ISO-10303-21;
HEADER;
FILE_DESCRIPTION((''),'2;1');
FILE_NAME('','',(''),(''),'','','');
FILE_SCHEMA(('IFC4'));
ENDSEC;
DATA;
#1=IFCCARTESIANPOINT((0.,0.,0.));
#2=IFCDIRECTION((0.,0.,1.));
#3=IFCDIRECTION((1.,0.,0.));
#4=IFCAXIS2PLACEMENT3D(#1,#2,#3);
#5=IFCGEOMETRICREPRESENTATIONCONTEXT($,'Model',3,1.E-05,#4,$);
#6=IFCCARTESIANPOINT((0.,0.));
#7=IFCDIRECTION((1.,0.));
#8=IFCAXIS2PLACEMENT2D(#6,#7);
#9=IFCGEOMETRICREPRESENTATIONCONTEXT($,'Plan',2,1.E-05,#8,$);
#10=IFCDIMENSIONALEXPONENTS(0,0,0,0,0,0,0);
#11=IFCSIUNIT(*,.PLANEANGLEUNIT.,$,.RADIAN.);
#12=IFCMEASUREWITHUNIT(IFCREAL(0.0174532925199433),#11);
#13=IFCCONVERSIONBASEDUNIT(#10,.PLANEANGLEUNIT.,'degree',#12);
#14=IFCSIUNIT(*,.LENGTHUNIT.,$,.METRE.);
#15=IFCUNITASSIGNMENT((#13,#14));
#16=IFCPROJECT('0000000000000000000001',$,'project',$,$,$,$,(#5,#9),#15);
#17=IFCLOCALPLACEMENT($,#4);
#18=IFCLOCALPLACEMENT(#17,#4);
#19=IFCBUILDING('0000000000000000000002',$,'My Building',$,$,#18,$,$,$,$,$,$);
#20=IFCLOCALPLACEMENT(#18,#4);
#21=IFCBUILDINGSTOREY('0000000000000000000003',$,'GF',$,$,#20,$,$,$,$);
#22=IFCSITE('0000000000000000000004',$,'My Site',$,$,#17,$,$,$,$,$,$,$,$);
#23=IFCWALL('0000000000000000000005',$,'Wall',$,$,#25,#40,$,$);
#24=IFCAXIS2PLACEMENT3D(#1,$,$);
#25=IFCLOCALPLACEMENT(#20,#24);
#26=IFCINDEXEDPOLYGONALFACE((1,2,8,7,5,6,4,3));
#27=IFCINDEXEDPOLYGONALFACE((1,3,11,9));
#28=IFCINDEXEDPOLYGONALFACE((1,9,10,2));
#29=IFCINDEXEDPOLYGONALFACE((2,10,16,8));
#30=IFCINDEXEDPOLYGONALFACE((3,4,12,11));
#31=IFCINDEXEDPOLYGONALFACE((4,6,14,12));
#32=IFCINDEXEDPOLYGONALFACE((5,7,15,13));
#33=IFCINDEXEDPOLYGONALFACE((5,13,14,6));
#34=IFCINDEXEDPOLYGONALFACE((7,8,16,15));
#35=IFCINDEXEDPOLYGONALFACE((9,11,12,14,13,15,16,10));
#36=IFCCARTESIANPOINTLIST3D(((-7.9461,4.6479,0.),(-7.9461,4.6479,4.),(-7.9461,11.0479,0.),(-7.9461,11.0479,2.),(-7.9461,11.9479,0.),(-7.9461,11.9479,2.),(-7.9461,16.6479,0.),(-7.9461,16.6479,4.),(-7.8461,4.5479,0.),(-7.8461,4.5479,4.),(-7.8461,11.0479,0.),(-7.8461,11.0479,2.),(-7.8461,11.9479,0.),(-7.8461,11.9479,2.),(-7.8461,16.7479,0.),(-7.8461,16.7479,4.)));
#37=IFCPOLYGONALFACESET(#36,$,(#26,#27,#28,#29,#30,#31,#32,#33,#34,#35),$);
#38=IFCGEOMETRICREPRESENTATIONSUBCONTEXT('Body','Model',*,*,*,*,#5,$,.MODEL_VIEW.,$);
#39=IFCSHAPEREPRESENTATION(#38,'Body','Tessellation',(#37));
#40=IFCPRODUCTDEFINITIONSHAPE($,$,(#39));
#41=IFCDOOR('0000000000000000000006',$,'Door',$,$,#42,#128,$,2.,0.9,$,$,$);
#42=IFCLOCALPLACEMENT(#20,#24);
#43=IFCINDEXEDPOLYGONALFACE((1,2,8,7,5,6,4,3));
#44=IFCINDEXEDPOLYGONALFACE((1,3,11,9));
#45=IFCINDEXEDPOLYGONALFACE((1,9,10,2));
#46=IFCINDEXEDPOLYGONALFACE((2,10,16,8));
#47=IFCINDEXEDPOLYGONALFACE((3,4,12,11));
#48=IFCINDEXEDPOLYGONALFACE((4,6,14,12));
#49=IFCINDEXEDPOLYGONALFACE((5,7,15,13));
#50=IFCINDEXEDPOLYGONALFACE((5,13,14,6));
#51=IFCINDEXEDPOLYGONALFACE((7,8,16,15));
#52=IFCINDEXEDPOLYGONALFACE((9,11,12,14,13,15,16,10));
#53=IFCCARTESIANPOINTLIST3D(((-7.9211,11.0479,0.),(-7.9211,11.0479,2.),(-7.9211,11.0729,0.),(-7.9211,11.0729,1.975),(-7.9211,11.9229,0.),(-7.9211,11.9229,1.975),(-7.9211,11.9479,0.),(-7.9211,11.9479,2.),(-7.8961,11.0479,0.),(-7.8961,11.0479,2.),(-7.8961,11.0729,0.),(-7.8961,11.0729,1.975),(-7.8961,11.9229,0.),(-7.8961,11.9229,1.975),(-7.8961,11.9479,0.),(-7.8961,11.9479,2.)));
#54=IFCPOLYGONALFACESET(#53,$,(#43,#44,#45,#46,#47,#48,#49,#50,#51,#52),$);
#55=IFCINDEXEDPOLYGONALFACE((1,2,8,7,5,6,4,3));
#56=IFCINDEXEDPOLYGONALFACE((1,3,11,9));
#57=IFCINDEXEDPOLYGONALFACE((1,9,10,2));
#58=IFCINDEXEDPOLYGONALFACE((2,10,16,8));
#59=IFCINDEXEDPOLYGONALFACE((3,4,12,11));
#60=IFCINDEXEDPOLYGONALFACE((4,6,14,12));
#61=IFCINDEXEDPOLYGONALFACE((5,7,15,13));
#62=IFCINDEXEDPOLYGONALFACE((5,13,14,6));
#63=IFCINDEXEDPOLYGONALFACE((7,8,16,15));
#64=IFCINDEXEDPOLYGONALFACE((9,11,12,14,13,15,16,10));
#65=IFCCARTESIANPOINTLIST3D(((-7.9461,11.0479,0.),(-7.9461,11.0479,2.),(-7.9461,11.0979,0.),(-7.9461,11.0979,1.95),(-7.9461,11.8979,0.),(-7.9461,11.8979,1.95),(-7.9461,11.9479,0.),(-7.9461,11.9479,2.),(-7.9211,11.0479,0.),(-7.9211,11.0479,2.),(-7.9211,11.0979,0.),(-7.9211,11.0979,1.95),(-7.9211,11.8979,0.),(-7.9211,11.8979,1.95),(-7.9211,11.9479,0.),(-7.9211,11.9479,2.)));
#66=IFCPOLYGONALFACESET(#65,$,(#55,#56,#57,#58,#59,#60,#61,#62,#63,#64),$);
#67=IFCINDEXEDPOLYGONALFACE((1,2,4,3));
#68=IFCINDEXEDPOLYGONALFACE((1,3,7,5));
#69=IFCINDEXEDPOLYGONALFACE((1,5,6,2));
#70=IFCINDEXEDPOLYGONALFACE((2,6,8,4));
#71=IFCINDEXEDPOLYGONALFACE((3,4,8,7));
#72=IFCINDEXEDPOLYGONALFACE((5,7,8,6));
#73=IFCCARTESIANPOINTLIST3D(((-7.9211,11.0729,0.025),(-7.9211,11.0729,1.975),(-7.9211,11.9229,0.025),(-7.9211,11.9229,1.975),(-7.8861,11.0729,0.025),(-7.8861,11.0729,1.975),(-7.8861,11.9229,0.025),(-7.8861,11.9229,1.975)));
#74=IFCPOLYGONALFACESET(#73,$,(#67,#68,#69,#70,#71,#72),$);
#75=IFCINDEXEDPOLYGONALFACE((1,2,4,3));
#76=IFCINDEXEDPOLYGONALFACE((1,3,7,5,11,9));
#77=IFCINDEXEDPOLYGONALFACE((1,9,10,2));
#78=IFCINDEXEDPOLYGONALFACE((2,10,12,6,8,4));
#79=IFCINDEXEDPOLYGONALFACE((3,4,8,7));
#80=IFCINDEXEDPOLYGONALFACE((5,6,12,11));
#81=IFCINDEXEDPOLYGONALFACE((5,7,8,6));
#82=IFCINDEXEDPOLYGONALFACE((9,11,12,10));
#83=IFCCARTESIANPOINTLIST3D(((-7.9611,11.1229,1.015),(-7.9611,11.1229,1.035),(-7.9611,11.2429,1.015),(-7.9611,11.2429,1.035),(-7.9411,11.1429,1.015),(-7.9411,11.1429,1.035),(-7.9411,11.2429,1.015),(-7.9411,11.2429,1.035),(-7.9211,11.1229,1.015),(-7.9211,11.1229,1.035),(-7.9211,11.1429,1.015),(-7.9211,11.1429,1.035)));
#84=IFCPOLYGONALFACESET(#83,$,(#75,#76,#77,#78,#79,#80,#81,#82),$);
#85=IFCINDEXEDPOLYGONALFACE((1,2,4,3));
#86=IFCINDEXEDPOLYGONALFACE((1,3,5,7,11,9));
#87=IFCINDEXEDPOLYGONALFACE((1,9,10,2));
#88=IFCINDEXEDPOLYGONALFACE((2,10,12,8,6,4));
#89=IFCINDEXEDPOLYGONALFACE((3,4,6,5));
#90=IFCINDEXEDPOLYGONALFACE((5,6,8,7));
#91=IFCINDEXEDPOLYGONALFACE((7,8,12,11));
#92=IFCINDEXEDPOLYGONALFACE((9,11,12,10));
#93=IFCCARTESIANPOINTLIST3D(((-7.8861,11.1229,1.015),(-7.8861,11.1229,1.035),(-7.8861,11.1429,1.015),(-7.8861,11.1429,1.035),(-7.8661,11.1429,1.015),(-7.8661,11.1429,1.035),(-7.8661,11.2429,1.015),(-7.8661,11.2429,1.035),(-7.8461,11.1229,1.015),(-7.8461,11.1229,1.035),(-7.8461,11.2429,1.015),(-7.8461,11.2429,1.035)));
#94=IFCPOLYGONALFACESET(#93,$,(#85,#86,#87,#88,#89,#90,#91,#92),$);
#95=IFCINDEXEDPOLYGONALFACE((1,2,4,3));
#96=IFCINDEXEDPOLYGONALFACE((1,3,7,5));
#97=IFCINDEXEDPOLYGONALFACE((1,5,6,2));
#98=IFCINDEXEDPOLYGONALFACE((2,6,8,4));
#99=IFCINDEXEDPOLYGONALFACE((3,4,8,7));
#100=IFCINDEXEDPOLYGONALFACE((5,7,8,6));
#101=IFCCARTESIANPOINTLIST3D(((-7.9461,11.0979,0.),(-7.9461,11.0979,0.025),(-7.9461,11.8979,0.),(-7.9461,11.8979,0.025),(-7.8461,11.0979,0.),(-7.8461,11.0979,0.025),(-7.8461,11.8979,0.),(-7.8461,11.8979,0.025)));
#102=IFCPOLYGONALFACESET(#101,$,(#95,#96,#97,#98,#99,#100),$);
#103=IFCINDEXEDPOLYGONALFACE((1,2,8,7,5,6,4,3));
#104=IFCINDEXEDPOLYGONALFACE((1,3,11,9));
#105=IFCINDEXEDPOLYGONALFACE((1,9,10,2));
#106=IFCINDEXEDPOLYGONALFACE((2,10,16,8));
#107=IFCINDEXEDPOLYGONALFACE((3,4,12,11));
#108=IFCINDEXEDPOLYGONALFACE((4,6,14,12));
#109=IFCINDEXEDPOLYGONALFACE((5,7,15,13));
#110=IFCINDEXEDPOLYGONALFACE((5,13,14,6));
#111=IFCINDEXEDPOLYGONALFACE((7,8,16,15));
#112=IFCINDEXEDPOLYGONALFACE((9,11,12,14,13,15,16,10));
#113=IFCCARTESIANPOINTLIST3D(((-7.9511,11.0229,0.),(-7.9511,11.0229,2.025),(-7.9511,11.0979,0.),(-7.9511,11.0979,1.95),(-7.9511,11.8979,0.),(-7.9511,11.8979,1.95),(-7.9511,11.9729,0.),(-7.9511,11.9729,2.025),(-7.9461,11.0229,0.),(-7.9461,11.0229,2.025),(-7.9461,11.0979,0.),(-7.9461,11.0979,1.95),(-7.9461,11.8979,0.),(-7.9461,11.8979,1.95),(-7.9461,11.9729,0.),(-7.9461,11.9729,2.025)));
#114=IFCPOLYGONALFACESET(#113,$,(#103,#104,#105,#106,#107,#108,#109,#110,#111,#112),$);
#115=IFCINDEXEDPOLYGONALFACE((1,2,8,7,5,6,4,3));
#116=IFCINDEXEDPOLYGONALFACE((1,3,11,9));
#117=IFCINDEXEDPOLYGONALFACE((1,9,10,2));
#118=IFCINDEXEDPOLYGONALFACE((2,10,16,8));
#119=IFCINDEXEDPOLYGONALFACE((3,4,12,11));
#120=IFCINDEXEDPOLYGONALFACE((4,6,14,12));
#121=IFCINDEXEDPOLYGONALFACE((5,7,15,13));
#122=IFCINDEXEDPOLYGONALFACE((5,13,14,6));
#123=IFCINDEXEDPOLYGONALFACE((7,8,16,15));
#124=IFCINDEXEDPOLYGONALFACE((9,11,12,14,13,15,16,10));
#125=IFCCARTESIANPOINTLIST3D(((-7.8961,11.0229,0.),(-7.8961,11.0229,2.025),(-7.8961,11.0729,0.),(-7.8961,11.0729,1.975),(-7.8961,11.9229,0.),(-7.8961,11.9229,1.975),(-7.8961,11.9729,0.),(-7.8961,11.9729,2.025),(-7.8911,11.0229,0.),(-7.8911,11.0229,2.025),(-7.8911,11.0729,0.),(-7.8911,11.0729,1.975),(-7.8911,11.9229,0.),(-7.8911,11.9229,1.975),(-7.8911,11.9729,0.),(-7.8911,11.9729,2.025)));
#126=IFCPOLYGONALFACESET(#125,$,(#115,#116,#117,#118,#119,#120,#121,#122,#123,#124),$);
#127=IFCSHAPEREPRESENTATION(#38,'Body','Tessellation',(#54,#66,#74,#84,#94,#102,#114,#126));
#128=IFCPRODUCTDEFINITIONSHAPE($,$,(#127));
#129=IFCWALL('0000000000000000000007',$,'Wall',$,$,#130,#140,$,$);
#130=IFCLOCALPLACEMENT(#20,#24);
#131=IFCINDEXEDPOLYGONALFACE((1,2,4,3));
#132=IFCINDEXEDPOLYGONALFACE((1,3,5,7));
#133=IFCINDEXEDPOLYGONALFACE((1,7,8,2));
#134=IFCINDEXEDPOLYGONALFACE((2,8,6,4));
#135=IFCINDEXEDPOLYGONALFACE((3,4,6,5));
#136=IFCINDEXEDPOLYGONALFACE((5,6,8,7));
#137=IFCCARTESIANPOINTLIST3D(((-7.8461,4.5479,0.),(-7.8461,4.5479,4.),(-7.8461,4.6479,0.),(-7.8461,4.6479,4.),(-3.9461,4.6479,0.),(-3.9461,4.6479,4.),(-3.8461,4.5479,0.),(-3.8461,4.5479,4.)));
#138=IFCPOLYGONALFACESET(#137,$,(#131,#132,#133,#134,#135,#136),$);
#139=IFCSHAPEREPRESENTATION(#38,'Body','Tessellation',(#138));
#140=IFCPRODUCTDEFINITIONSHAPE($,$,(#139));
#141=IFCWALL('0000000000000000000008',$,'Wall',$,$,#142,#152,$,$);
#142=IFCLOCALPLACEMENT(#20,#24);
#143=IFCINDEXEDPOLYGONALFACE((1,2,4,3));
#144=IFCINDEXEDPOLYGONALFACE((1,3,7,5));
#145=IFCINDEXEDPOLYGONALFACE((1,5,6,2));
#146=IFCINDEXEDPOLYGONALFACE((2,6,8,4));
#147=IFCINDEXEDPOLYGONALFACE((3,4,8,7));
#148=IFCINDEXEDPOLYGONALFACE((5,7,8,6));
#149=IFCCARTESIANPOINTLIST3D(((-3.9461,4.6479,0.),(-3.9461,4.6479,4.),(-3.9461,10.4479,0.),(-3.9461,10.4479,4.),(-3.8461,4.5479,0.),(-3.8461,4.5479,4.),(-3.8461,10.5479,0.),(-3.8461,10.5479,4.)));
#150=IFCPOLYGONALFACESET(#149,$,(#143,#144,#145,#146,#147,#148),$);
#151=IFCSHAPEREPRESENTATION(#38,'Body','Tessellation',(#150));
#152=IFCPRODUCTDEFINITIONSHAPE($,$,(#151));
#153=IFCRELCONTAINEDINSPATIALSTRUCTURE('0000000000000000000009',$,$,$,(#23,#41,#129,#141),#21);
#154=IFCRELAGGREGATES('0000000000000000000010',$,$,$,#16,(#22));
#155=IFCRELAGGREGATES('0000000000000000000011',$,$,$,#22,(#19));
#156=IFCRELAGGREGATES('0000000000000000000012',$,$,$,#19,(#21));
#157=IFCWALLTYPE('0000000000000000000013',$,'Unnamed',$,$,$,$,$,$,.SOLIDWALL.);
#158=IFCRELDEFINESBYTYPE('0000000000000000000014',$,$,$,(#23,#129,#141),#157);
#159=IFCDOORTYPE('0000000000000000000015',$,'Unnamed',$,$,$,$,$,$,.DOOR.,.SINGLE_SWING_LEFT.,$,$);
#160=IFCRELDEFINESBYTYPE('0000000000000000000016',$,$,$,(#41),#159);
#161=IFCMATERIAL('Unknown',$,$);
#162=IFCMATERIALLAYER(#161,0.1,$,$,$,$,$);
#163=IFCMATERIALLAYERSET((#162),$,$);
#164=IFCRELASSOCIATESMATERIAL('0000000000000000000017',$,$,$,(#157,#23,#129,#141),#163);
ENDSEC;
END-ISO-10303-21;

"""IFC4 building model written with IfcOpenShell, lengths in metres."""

from ifc_helpers import new_model, entity, si_unit, converted_unit, frame, origin_with_axes, origin_2d_with_axis, place, context, subcontext, project, spatial, line, indexed_curve, outline, extrude, shape, source, transform, mapped, material, layer, layer_set, layer_usage, type_object, type_shapes, element, fill, save


model = new_model("IFC4")

# Units and contexts
model_context = context("Model", 3, precision=1e-05, world=origin_with_axes())
plan_context = context("Plan", 2, precision=1e-05, world=origin_2d_with_axis())
body_context_1 = subcontext(model_context, "Body", "Model", "MODEL_VIEW")
body_context_2 = subcontext(plan_context, "Body", "Plan", "PLAN_VIEW")
ifc_project = project(units=[converted_unit("PLANEANGLEUNIT", "degree", entity("IfcReal", 0.0174532925199433), si_unit("PLANEANGLEUNIT", "RADIAN"), dimensions=[0, 0, 0, 0, 0, 0, 0]), si_unit("LENGTHUNIT", "METRE")], contexts=[model_context, plan_context])

# Site, building, storey
site_placement = place(None, origin_with_axes())
site = spatial("IfcSite", under=ifc_project, at=site_placement, Name="My Site")
building_placement = place(site_placement, origin_with_axes())
building = spatial("IfcBuilding", under=site, at=building_placement, Name="My Building")
storey_placement = place(building_placement, origin_with_axes())
storey = spatial("IfcBuildingStorey", under=building, at=storey_placement, Name="GF")

# Shared definitions
ifc_material = material(Name="Unknown")

# Wall, opening, door
ifc_layer_1 = layer(ifc_material, 0.1)
ifc_layer_set_1 = layer_set([ifc_layer_1])
ifc_layer_usage_1 = layer_usage(ifc_layer_set_1, "AXIS2", "POSITIVE", 0.0)
wall_type = type_object("IfcWallType", Name="Unnamed", PredefinedType="SOLIDWALL", material=ifc_layer_set_1)
wall_1_placement = place(storey_placement, frame((-7.9461, 16.6479, 0.0), z_axis=(0.0, 0.0, 1.0), x_axis=(0.0, -1.0, 0.0)))
wall_1 = element("IfcWall", 1, at=wall_1_placement, inside=storey, type_object=wall_type, material=ifc_layer_usage_1, Name="Wall", context=body_context_1, shape_type="SweptSolid", body=[
    extrude(outline(indexed_curve([(0.0, 0.0), (-0.1, 0.1), (12.1, 0.1), (12.0, 0.0)], segments=[line(1, 2, 3, 4, 1)])), origin_with_axes(), (0.0, 0.0, 1.0), 4.0),
])
shared_shape_1 = source(origin_with_axes(), body_context_1, "Body", "SweptSolid", [
    extrude(outline(indexed_curve([(0.0, 0.0), (0.9, 0.0), (0.9, 2.0), (0.0, 2.0)], segments=[line(1, 2, 3, 4, 1)])), frame((0.0, -0.6, 0.0), z_axis=(0.0, -1.0, 0.0), x_axis=(1.0, 0.0, 0.0)), (0.0, 0.0, -1.0), 1.2),
])
opening_1_placement = place(wall_1_placement, frame((4.7001, 0.0, 0.0), z_axis=(0.0, 0.0, 1.0), x_axis=(1.0, 0.0, 0.0)))
opening_1 = element("IfcOpeningElement", 2, at=opening_1_placement, cuts=wall_1, PredefinedType="OPENING", context=body_context_1, shape_type="MappedRepresentation", body=[
    mapped(shared_shape_1, transform((0.0, 0.0, 0.0), x_axis=(1.0, 0.0, 0.0), y_axis=(0.0, 1.0, 0.0), z_axis=(0.0, 0.0, 1.0), scale=1.0)),
])
door_type = type_object("IfcDoorType", Name="Unnamed", OperationType="SINGLE_SWING_LEFT", PredefinedType="DOOR")
shared_shape_2 = source(origin_with_axes(), body_context_1, "Body", "SweptSolid", [
    extrude(outline(indexed_curve([(0.0, 0.0), (0.0, 2.0), (0.9, 2.0), (0.9, 0.0), (0.875, 0.0), (0.875, 1.975), (0.025, 1.975), (0.025, 0.0)], segments=[line(1, 2, 3, 4, 5, 6, 7, 8, 1)])), frame((0.0, 0.025, 0.0), z_axis=(0.0, -1.0, 0.0), x_axis=(1.0, 0.0, 0.0)), (0.0, 0.0, -1.0), 0.025),
    extrude(outline(indexed_curve([(0.0, 0.0), (0.0, 2.0), (0.9, 2.0), (0.9, 0.0), (0.85, 0.0), (0.85, 1.95), (0.05, 1.95), (0.05, 0.0)], segments=[line(1, 2, 3, 4, 5, 6, 7, 8, 1)])), frame((0.0, 0.0, 0.0), z_axis=(0.0, -1.0, 0.0), x_axis=(1.0, 0.0, 0.0)), (0.0, 0.0, -1.0), 0.025),
    extrude(outline(indexed_curve([(0.0, 0.0), (0.85, 0.0), (0.85, 0.035), (0.0, 0.035)], segments=[line(1, 2, 3, 4, 1)])), frame((0.025, 0.025, 0.025), z_axis=(0.0, 0.0, 1.0), x_axis=(1.0, 0.0, 0.0)), (0.0, 0.0, 1.0), 1.95),
    extrude(outline(indexed_curve([(0.0, 0.0), (0.0, -0.04), (-0.12, -0.04), (-0.12, -0.02), (-0.02, -0.02), (-0.02, 0.0)], segments=[line(1, 2, 3, 4, 5, 6, 1)])), frame((0.825, 0.025, 1.015), z_axis=(0.0, 0.0, 1.0), x_axis=(1.0, 0.0, 0.0)), (0.0, 0.0, 1.0), 0.02),
    extrude(outline(indexed_curve([(0.0, 0.0), (0.0, 0.04), (-0.12, 0.04), (-0.12, 0.02), (-0.02, 0.02), (-0.02, 0.0)], segments=[line(1, 2, 3, 4, 5, 6, 1)])), frame((0.825, 0.06, 1.015), z_axis=(0.0, 0.0, 1.0), x_axis=(1.0, 0.0, 0.0)), (0.0, 0.0, 1.0), 0.02),
    extrude(outline(indexed_curve([(0.0, 0.0), (0.8, 0.0), (0.8, 0.1), (0.0, 0.1)], segments=[line(1, 2, 3, 4, 1)])), frame((0.05, 0.0, 0.0), z_axis=(0.0, 0.0, 1.0), x_axis=(1.0, 0.0, 0.0)), (0.0, 0.0, 1.0), 0.025),
    extrude(outline(indexed_curve([(0.0, 0.0), (0.0, 2.025), (0.95, 2.025), (0.95, 0.0), (0.875, 0.0), (0.875, 1.95), (0.075, 1.95), (0.075, 0.0)], segments=[line(1, 2, 3, 4, 5, 6, 7, 8, 1)])), frame((-0.025, -0.005, 0.0), z_axis=(0.0, -1.0, 0.0), x_axis=(1.0, 0.0, 0.0)), (0.0, 0.0, -1.0), 0.005),
    extrude(outline(indexed_curve([(0.0, 0.0), (0.0, 2.025), (0.95, 2.025), (0.95, 0.0), (0.9, 0.0), (0.9, 1.975), (0.05, 1.975), (0.05, 0.0)], segments=[line(1, 2, 3, 4, 5, 6, 7, 8, 1)])), frame((-0.025, 0.05, 0.0), z_axis=(0.0, -1.0, 0.0), x_axis=(1.0, 0.0, 0.0)), (0.0, 0.0, -1.0), 0.005),
])
shared_shape_3 = source(origin_with_axes(), body_context_2, "Body", "Curve2D", [
    entity("IfcIndexedPolyCurve", entity("IfcCartesianPointList2D", [[0.0, 0.0], [0.0, 0.05], [0.025, 0.05], [0.025, 0.025], [0.05, 0.025], [0.05, 0.0]]), [entity("IfcLineIndex", [1, 2, 3, 4, 5, 6, 1])]),
    entity("IfcIndexedPolyCurve", entity("IfcCartesianPointList2D", [[0.9, 0.0], [0.9, 0.05], [0.875, 0.05], [0.875, 0.025], [0.85, 0.025], [0.85, 0.0]]), [entity("IfcLineIndex", [1, 2, 3, 4, 5, 6, 1])]),
    entity("IfcTrimmedCurve", entity("IfcEllipse", entity("IfcAxis2Placement2D", entity("IfcCartesianPoint", [0.06, 0.05]), entity("IfcDirection", [1.0, 0.0])), 0.815, 0.85), [entity("IfcCartesianPoint", [0.875, 0.05])], [entity("IfcCartesianPoint", [0.06, 0.9])], True, "CARTESIAN"),
    entity("IfcIndexedPolyCurve", entity("IfcCartesianPointList2D", [[0.025, 0.05], [0.06, 0.05], [0.06, 0.9], [0.025, 0.9]]), [entity("IfcLineIndex", [1, 2, 3, 4, 1])]),
])
type_shapes(door_type, [shared_shape_2, shared_shape_3])
door_1_placement = place(opening_1_placement, frame((0.0, 0.0, 0.0), z_axis=(0.0, 0.0, 1.0), x_axis=(1.0, 0.0, 0.0)))
door_1 = element("IfcDoor", 3, at=door_1_placement, inside=storey, type_object=door_type, Name="Door", OverallHeight=2.0, OverallWidth=0.9, shapes=[
    shape(body_context_1, "Body", "MappedRepresentation", [mapped(shared_shape_2, transform((0.0, 0.0, 0.0), x_axis=(1.0, 0.0, 0.0), y_axis=(0.0, 1.0, 0.0), z_axis=(0.0, 0.0, 1.0), scale=1.0))]),
    shape(body_context_2, "Body", "MappedRepresentation", [mapped(shared_shape_3, transform((0.0, 0.0, 0.0), x_axis=(1.0, 0.0, 0.0), y_axis=(0.0, 1.0, 0.0), z_axis=(0.0, 0.0, 1.0), scale=1.0))]),
])
fill(opening_1, door_1)

# Walls
ifc_layer_usage_2 = layer_usage(ifc_layer_set_1, "AXIS2", "POSITIVE", 0.0)
wall_2_placement = place(storey_placement, frame((-7.8461, 4.5479, 0.0), z_axis=(0.0, 0.0, 1.0), x_axis=(1.0, 0.0, 0.0)))
element("IfcWall", 4, at=wall_2_placement, inside=storey, type_object=wall_type, material=ifc_layer_usage_2, Name="Wall", context=body_context_1, shape_type="SweptSolid", body=[
    extrude(outline(indexed_curve([(0.0, 0.0), (0.0, 0.1), (3.9, 0.1), (4.0, 0.0)], segments=[line(1, 2, 3, 4, 1)])), origin_with_axes(), (0.0, 0.0, 1.0), 4.0),
])
ifc_layer_usage_3 = layer_usage(ifc_layer_set_1, "AXIS2", "POSITIVE", 0.0)
wall_3_placement = place(storey_placement, frame((-3.8461, 4.5479, 0.0), z_axis=(0.0, 0.0, 1.0), x_axis=(0.0, 1.0, 0.0)))
element("IfcWall", 5, at=wall_3_placement, inside=storey, type_object=wall_type, material=ifc_layer_usage_3, Name="Wall", context=body_context_1, shape_type="SweptSolid", body=[
    extrude(outline(indexed_curve([(0.0, 0.0), (0.1, 0.1), (5.9, 0.1), (6.0, 0.0)], segments=[line(1, 2, 3, 4, 1)])), origin_with_axes(), (0.0, 0.0, 1.0), 4.0),
])

save(model, "model.ifc")
